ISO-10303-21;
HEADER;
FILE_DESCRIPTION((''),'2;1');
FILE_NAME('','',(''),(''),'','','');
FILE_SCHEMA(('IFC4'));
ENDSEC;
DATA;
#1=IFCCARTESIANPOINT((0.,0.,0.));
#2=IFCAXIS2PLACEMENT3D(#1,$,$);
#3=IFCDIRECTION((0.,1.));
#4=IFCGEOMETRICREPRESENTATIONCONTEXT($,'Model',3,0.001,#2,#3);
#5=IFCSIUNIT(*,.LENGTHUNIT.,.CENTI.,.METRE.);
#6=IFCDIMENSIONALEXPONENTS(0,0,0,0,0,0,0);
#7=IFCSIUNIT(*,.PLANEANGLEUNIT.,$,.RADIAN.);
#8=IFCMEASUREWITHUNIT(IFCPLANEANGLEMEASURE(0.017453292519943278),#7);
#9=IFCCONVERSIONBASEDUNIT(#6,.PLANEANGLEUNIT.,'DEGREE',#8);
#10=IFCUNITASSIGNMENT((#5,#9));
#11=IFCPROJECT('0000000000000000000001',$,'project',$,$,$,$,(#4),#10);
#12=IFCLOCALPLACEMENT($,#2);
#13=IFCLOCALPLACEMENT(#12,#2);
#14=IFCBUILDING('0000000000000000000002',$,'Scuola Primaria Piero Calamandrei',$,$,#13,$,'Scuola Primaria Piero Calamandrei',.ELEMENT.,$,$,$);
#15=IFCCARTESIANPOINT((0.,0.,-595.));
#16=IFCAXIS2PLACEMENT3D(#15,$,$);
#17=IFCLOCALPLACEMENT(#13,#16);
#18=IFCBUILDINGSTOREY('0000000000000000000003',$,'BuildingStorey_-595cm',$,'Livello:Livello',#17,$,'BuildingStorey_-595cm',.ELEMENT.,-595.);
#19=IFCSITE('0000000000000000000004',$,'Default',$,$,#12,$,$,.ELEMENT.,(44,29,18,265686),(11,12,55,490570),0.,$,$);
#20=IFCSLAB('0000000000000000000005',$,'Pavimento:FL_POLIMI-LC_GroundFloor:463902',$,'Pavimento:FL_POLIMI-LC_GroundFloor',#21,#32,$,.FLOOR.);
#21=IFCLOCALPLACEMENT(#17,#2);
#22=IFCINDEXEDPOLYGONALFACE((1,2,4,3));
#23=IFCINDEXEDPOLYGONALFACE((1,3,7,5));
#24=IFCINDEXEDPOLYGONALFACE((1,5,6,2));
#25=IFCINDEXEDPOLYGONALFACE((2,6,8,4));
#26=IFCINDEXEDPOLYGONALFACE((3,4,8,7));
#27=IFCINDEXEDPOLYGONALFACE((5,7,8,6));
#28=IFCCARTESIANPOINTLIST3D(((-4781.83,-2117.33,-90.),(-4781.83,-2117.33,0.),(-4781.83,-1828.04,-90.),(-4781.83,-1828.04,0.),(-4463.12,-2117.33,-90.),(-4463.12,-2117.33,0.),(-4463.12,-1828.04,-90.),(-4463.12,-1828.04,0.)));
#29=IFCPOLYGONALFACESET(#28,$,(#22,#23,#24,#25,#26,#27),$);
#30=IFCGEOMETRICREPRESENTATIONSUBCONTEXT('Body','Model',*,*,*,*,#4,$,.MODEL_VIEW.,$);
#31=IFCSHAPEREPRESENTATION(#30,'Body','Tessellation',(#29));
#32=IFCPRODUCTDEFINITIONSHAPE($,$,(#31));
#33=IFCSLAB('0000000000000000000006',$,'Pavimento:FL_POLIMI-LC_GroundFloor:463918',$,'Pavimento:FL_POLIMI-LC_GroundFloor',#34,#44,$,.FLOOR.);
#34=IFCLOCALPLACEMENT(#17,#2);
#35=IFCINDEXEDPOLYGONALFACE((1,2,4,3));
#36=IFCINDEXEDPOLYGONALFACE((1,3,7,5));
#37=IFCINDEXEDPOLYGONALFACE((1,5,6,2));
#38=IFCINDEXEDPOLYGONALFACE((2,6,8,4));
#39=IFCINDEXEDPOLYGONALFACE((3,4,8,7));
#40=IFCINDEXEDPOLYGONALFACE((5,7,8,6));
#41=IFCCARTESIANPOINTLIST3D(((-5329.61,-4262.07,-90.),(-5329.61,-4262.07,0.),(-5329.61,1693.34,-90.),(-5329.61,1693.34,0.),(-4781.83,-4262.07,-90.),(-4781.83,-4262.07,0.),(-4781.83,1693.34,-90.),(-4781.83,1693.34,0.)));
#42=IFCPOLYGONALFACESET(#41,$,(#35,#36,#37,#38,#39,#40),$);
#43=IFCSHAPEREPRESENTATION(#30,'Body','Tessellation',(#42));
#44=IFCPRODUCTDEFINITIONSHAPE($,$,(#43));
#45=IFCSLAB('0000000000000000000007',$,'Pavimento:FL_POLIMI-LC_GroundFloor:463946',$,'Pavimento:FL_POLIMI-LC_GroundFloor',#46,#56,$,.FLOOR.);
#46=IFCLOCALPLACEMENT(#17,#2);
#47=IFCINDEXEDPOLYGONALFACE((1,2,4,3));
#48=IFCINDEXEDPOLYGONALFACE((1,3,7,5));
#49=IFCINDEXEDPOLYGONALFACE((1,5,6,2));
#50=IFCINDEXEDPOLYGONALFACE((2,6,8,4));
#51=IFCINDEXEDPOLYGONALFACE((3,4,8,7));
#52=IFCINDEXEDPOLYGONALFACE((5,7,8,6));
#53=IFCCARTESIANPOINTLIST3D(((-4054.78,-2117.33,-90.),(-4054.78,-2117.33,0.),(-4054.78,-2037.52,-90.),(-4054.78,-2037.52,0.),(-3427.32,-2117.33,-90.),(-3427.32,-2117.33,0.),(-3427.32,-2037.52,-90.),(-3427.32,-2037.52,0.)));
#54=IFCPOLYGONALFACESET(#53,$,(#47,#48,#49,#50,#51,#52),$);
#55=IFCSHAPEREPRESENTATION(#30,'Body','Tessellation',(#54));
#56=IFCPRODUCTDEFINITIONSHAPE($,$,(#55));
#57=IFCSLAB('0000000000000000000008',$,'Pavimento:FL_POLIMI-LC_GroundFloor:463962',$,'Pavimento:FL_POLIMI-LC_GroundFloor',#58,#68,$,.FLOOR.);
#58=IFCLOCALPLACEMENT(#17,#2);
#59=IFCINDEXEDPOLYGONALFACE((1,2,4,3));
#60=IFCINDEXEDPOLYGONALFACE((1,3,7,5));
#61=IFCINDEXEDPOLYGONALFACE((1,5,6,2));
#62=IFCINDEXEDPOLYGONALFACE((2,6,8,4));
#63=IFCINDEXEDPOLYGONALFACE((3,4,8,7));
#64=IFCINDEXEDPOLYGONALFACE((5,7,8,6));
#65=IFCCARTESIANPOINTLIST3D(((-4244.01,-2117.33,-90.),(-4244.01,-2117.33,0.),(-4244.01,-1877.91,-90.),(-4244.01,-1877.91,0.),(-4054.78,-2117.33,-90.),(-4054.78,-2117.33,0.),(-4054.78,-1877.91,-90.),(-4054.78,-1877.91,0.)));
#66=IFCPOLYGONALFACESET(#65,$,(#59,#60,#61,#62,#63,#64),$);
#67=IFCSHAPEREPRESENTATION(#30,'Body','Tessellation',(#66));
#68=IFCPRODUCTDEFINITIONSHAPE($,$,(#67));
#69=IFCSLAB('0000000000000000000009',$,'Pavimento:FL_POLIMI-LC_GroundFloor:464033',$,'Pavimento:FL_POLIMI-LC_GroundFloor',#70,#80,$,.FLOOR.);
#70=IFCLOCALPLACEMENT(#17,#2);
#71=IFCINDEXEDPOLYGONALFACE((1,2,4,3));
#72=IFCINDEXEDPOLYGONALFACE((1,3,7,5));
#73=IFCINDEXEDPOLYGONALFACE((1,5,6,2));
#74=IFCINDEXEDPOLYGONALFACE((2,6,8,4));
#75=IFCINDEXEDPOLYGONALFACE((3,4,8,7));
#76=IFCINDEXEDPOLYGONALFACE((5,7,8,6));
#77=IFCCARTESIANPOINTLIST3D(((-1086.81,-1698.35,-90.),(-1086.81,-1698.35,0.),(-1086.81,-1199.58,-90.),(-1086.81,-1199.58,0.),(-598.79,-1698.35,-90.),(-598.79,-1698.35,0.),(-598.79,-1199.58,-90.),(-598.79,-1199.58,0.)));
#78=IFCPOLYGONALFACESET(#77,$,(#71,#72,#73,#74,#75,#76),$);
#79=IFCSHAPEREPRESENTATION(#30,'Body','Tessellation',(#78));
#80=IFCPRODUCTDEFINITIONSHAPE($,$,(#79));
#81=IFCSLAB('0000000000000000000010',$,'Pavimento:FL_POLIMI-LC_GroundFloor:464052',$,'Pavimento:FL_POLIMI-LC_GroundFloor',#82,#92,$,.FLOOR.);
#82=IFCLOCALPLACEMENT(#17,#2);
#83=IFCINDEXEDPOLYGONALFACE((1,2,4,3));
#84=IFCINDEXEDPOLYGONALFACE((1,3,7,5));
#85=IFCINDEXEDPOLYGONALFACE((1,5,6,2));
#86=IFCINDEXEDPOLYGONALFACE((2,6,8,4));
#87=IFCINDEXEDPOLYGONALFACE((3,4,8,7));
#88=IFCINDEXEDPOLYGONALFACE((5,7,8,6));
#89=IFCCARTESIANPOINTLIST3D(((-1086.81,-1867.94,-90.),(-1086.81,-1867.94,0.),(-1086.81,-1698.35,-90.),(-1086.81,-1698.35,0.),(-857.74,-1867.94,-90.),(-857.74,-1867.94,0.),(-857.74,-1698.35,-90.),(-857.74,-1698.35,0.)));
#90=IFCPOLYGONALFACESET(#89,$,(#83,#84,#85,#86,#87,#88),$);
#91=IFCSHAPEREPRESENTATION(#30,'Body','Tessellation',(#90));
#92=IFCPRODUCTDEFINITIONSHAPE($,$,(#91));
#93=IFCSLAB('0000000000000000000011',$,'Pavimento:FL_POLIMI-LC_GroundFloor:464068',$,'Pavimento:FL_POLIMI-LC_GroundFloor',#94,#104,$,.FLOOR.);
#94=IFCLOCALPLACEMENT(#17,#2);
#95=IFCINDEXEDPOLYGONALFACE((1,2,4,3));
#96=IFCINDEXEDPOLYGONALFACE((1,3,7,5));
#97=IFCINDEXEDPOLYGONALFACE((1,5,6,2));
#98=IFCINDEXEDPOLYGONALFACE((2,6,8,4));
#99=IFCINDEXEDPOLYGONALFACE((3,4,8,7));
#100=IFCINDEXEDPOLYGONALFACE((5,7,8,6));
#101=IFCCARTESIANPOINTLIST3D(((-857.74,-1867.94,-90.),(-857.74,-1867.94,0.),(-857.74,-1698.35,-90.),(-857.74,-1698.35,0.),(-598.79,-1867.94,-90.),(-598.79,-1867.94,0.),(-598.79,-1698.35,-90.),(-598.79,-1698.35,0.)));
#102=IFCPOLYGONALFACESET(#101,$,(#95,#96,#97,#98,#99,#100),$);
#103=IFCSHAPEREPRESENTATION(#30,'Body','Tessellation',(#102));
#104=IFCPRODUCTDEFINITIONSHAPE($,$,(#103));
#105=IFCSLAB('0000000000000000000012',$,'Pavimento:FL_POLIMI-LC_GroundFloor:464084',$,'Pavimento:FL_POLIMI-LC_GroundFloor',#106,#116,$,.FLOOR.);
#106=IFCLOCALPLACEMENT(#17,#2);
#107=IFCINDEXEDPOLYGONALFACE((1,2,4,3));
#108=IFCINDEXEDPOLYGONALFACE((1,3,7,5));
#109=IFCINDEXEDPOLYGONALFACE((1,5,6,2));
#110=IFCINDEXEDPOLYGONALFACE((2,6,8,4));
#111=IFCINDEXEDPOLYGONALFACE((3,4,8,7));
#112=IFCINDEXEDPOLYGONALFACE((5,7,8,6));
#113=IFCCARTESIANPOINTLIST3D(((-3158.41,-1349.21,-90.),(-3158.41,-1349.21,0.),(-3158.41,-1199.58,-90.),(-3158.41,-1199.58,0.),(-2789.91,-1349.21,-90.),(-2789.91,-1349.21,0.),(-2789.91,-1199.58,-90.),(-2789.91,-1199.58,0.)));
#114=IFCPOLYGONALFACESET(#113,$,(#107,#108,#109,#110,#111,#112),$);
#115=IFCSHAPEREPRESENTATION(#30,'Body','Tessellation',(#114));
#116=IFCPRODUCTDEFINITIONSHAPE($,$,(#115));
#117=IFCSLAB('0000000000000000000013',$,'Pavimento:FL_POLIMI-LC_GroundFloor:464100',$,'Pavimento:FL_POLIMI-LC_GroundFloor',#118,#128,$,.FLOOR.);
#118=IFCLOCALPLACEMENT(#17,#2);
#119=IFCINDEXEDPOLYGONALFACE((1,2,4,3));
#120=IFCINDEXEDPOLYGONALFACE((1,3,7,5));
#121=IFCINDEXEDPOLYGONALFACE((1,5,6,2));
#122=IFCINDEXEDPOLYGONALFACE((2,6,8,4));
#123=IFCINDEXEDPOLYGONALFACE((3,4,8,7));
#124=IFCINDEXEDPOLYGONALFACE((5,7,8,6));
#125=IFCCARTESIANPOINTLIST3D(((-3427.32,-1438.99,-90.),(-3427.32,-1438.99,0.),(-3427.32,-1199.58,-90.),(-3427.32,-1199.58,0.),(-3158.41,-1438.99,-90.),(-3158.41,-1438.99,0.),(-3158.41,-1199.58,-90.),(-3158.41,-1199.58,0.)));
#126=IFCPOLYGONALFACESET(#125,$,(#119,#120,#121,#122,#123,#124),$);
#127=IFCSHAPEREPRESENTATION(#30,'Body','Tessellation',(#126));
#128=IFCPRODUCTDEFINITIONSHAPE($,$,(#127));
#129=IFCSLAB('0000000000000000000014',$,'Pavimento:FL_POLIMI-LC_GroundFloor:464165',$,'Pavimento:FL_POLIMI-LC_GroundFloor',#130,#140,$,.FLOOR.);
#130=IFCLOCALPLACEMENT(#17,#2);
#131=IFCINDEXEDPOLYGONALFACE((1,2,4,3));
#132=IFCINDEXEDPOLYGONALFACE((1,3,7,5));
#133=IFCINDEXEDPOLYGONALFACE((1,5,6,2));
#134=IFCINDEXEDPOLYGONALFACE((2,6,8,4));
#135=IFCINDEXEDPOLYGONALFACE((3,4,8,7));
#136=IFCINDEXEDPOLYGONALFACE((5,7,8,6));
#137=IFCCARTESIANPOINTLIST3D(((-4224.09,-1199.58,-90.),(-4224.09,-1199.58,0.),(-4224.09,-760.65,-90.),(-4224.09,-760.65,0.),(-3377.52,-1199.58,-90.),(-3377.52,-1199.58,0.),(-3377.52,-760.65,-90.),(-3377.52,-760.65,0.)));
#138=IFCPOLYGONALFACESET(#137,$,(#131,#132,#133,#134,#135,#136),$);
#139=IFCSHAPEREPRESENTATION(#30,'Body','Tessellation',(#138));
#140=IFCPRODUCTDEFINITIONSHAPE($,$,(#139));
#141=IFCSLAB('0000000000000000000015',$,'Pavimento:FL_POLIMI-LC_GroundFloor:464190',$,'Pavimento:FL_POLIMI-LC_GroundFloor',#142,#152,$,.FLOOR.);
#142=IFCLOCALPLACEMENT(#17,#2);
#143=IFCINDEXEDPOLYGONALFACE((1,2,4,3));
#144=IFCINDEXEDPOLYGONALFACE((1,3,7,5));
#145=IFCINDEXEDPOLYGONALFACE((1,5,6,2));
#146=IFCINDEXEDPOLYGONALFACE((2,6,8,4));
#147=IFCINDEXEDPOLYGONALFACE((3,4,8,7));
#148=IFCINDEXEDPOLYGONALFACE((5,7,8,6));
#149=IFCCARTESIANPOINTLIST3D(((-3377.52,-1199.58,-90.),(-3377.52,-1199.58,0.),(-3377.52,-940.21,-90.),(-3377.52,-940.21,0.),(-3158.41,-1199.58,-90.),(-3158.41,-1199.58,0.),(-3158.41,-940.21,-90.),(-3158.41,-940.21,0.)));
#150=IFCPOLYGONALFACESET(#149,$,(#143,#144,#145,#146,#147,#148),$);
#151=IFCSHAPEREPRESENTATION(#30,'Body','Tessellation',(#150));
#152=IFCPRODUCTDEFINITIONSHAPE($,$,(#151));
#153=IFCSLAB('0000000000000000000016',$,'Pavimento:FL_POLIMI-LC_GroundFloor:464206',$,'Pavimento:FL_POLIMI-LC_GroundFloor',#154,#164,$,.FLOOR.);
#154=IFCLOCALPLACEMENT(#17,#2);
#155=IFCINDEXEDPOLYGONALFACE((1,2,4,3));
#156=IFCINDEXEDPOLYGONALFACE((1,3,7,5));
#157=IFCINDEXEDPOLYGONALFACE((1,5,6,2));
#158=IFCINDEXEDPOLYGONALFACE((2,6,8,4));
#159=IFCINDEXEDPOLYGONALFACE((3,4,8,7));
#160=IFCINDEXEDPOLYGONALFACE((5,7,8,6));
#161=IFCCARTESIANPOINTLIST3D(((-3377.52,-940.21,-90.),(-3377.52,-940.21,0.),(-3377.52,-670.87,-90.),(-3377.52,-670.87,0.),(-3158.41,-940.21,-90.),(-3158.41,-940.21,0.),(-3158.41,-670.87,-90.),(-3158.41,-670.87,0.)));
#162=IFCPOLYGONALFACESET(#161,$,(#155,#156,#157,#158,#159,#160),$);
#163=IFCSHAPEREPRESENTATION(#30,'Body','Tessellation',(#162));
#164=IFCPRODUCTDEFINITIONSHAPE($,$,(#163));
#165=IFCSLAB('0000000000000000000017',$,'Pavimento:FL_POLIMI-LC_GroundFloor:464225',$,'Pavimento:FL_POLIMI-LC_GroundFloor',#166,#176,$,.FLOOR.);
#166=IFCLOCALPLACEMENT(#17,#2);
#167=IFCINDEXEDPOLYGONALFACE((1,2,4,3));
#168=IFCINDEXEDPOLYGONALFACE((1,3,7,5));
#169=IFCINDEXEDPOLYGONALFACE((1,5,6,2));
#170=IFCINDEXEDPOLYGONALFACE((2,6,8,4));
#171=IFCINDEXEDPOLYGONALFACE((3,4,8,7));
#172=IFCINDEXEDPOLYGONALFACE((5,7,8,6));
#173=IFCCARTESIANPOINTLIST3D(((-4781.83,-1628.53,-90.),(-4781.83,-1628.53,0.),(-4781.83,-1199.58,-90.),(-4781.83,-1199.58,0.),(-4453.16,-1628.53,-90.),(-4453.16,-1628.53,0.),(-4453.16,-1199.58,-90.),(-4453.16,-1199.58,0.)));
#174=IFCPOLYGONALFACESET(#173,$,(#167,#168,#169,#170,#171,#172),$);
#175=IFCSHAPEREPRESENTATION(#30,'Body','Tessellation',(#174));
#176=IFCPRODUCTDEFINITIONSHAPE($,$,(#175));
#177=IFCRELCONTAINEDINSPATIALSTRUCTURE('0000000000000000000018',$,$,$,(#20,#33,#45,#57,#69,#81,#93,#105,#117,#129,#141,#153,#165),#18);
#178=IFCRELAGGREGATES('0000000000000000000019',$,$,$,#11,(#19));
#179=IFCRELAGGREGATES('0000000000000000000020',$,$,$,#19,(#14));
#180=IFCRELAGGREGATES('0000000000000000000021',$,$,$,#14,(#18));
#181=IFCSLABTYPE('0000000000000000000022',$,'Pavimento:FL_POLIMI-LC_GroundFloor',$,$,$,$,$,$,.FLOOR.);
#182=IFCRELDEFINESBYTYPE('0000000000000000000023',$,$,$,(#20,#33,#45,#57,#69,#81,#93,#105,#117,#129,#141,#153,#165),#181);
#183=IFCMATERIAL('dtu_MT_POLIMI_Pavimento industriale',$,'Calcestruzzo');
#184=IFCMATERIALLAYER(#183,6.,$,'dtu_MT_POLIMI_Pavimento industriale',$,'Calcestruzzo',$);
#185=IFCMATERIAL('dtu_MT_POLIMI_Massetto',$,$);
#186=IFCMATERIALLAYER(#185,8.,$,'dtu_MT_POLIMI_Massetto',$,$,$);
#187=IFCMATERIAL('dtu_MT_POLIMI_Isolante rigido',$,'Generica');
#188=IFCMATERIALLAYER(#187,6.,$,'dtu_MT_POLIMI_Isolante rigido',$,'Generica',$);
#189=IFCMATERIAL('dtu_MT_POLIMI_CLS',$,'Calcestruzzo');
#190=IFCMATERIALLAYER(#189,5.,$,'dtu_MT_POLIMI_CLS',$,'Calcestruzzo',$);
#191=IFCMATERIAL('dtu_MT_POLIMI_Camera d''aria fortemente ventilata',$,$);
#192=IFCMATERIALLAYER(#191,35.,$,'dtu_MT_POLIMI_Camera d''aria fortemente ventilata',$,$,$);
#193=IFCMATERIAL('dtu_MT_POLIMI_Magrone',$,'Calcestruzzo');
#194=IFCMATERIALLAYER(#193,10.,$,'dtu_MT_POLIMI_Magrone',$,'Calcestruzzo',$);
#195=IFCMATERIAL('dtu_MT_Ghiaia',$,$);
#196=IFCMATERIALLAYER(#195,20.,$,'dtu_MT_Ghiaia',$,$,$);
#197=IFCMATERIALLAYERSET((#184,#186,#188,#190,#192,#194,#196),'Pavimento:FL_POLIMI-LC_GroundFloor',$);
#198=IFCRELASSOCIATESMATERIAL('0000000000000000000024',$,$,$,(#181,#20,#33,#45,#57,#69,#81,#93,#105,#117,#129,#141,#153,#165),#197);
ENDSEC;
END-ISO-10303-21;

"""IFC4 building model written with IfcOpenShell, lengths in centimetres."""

from ifc_helpers import new_model, entity, si_unit, converted_unit, direction, frame, frame_2d, origin, origin_2d_with_axis, place, context, subcontext, project, spatial, rectangle, extrude, material, layer, layer_set, layer_usage, type_object, element, save


model = new_model("IFC4")

# Units and contexts
model_context = context("Model", 3, precision=0.001, world=origin(), true_north=direction((0.0, 1.0)))
body_context = subcontext(model_context, "Body", "Model", "MODEL_VIEW")
ifc_project = project(units=[si_unit("LENGTHUNIT", "METRE", prefix="CENTI"), converted_unit("PLANEANGLEUNIT", "DEGREE", entity("IfcPlaneAngleMeasure", 0.017453292519943278), si_unit("PLANEANGLEUNIT", "RADIAN"), dimensions=[0, 0, 0, 0, 0, 0, 0])], contexts=[model_context])

# Site, building, storey
site_placement = place(None, origin())
site = spatial("IfcSite", under=ifc_project, at=site_placement, Name="Default", CompositionType="ELEMENT", RefLatitude=(44, 29, 18, 265686), RefLongitude=(11, 12, 55, 490570), RefElevation=0.0)
building_placement = place(site_placement, origin())
building = spatial("IfcBuilding", under=site, at=building_placement, Name="Scuola Primaria Piero Calamandrei", LongName="Scuola Primaria Piero Calamandrei", CompositionType="ELEMENT")
storey_placement = place(building_placement, frame((0.0, 0.0, -595.0)))
storey = spatial("IfcBuildingStorey", under=building, at=storey_placement, Name="BuildingStorey_-595cm", ObjectType="Livello:Livello", LongName="BuildingStorey_-595cm", CompositionType="ELEMENT", Elevation=-595.0)

# Slabs
ifc_material_1 = material(Name="dtu_MT_POLIMI_Pavimento industriale", Category="Calcestruzzo")
ifc_layer_1 = layer(ifc_material_1, 6.0, Name="dtu_MT_POLIMI_Pavimento industriale", Category="Calcestruzzo")
ifc_material_2 = material(Name="dtu_MT_POLIMI_Massetto")
ifc_layer_2 = layer(ifc_material_2, 8.0, Name="dtu_MT_POLIMI_Massetto")
ifc_material_3 = material(Name="dtu_MT_POLIMI_Isolante rigido", Category="Generica")
ifc_layer_3 = layer(ifc_material_3, 6.0, Name="dtu_MT_POLIMI_Isolante rigido", Category="Generica")
ifc_material_4 = material(Name="dtu_MT_POLIMI_CLS", Category="Calcestruzzo")
ifc_layer_4 = layer(ifc_material_4, 5.0, Name="dtu_MT_POLIMI_CLS", Category="Calcestruzzo")
ifc_material_5 = material(Name="dtu_MT_POLIMI_Camera d'aria fortemente ventilata")
ifc_layer_5 = layer(ifc_material_5, 35.0, Name="dtu_MT_POLIMI_Camera d'aria fortemente ventilata")
ifc_material_6 = material(Name="dtu_MT_POLIMI_Magrone", Category="Calcestruzzo")
ifc_layer_6 = layer(ifc_material_6, 10.0, Name="dtu_MT_POLIMI_Magrone", Category="Calcestruzzo")
ifc_material_7 = material(Name="dtu_MT_Ghiaia")
ifc_layer_7 = layer(ifc_material_7, 20.0, Name="dtu_MT_Ghiaia")
ifc_layer_set_1 = layer_set([ifc_layer_1, ifc_layer_2, ifc_layer_3, ifc_layer_4, ifc_layer_5, ifc_layer_6, ifc_layer_7], Name="Pavimento:FL_POLIMI-LC_GroundFloor")
slab_type = type_object("IfcSlabType", Name="Pavimento:FL_POLIMI-LC_GroundFloor", PredefinedType="FLOOR", material=ifc_layer_set_1)
ifc_layer_usage_1 = layer_usage(ifc_layer_set_1, "AXIS3", "POSITIVE", 0.0)
slab_1_placement = place(storey_placement, origin())
element("IfcSlab", 1, at=slab_1_placement, inside=storey, type_object=slab_type, material=ifc_layer_usage_1, Name="Pavimento:FL_POLIMI-LC_GroundFloor:463902", ObjectType="Pavimento:FL_POLIMI-LC_GroundFloor", PredefinedType="FLOOR", context=body_context, shape_type="SweptSolid", body=[
    extrude(rectangle(XDim=289.29, YDim=318.71, at=frame_2d((0.0, 0.0), x_axis=(1.0, 0.0))), frame((-4622.48, -1972.68, 0.0), z_axis=(0.0, 0.0, -1.0), x_axis=(0.0, 1.0, 0.0)), (0.0, 0.0, 1.0), 90.0),
])
ifc_layer_usage_2 = layer_usage(ifc_layer_set_1, "AXIS3", "POSITIVE", 0.0)
slab_2_placement = place(storey_placement, origin())
element("IfcSlab", 2, at=slab_2_placement, inside=storey, type_object=slab_type, material=ifc_layer_usage_2, Name="Pavimento:FL_POLIMI-LC_GroundFloor:463918", ObjectType="Pavimento:FL_POLIMI-LC_GroundFloor", PredefinedType="FLOOR", context=body_context, shape_type="SweptSolid", body=[
    extrude(rectangle(XDim=5955.41, YDim=547.78, at=frame_2d((0.0, 0.0), x_axis=(1.0, 0.0))), frame((-5055.72, -1284.37, 0.0), z_axis=(0.0, 0.0, -1.0), x_axis=(0.0, 1.0, 0.0)), (0.0, 0.0, 1.0), 90.0),
])
ifc_layer_usage_3 = layer_usage(ifc_layer_set_1, "AXIS3", "POSITIVE", 0.0)
slab_3_placement = place(storey_placement, origin())
element("IfcSlab", 3, at=slab_3_placement, inside=storey, type_object=slab_type, material=ifc_layer_usage_3, Name="Pavimento:FL_POLIMI-LC_GroundFloor:463946", ObjectType="Pavimento:FL_POLIMI-LC_GroundFloor", PredefinedType="FLOOR", context=body_context, shape_type="SweptSolid", body=[
    extrude(rectangle(XDim=79.8, YDim=627.46, at=frame_2d((0.0, 0.0), x_axis=(1.0, 0.0))), frame((-3741.05, -2077.42, 0.0), z_axis=(0.0, 0.0, -1.0), x_axis=(0.0, 1.0, 0.0)), (0.0, 0.0, 1.0), 90.0),
])
ifc_layer_usage_4 = layer_usage(ifc_layer_set_1, "AXIS3", "POSITIVE", 0.0)
slab_4_placement = place(storey_placement, origin())
element("IfcSlab", 4, at=slab_4_placement, inside=storey, type_object=slab_type, material=ifc_layer_usage_4, Name="Pavimento:FL_POLIMI-LC_GroundFloor:463962", ObjectType="Pavimento:FL_POLIMI-LC_GroundFloor", PredefinedType="FLOOR", context=body_context, shape_type="SweptSolid", body=[
    extrude(rectangle(XDim=239.41, YDim=189.23, at=frame_2d((0.0, 0.0), x_axis=(1.0, 0.0))), frame((-4149.39, -1997.62, 0.0), z_axis=(0.0, 0.0, -1.0), x_axis=(0.0, 1.0, 0.0)), (0.0, 0.0, 1.0), 90.0),
])
ifc_layer_usage_5 = layer_usage(ifc_layer_set_1, "AXIS3", "POSITIVE", 0.0)
slab_5_placement = place(storey_placement, origin())
element("IfcSlab", 5, at=slab_5_placement, inside=storey, type_object=slab_type, material=ifc_layer_usage_5, Name="Pavimento:FL_POLIMI-LC_GroundFloor:464033", ObjectType="Pavimento:FL_POLIMI-LC_GroundFloor", PredefinedType="FLOOR", context=body_context, shape_type="SweptSolid", body=[
    extrude(rectangle(XDim=498.78, YDim=488.02, at=frame_2d((0.0, 0.0), x_axis=(1.0, 0.0))), frame((-842.8, -1448.96, 0.0), z_axis=(0.0, 0.0, -1.0), x_axis=(0.0, 1.0, 0.0)), (0.0, 0.0, 1.0), 90.0),
])
ifc_layer_usage_6 = layer_usage(ifc_layer_set_1, "AXIS3", "POSITIVE", 0.0)
slab_6_placement = place(storey_placement, origin())
element("IfcSlab", 6, at=slab_6_placement, inside=storey, type_object=slab_type, material=ifc_layer_usage_6, Name="Pavimento:FL_POLIMI-LC_GroundFloor:464052", ObjectType="Pavimento:FL_POLIMI-LC_GroundFloor", PredefinedType="FLOOR", context=body_context, shape_type="SweptSolid", body=[
    extrude(rectangle(XDim=169.58, YDim=229.07, at=frame_2d((0.0, 0.0), x_axis=(1.0, 0.0))), frame((-972.28, -1783.15, 0.0), z_axis=(0.0, 0.0, -1.0), x_axis=(0.0, 1.0, 0.0)), (0.0, 0.0, 1.0), 90.0),
])
ifc_layer_usage_7 = layer_usage(ifc_layer_set_1, "AXIS3", "POSITIVE", 0.0)
slab_7_placement = place(storey_placement, origin())
element("IfcSlab", 7, at=slab_7_placement, inside=storey, type_object=slab_type, material=ifc_layer_usage_7, Name="Pavimento:FL_POLIMI-LC_GroundFloor:464068", ObjectType="Pavimento:FL_POLIMI-LC_GroundFloor", PredefinedType="FLOOR", context=body_context, shape_type="SweptSolid", body=[
    extrude(rectangle(XDim=169.58, YDim=258.95, at=frame_2d((0.0, 0.0), x_axis=(1.0, 0.0))), frame((-728.27, -1783.15, 0.0), z_axis=(0.0, 0.0, -1.0), x_axis=(0.0, 1.0, 0.0)), (0.0, 0.0, 1.0), 90.0),
])
ifc_layer_usage_8 = layer_usage(ifc_layer_set_1, "AXIS3", "POSITIVE", 0.0)
slab_8_placement = place(storey_placement, origin())
element("IfcSlab", 8, at=slab_8_placement, inside=storey, type_object=slab_type, material=ifc_layer_usage_8, Name="Pavimento:FL_POLIMI-LC_GroundFloor:464084", ObjectType="Pavimento:FL_POLIMI-LC_GroundFloor", PredefinedType="FLOOR", context=body_context, shape_type="SweptSolid", body=[
    extrude(rectangle(XDim=149.63, YDim=368.51, at=frame_2d((0.0, 0.0), x_axis=(1.0, 0.0))), frame((-2974.16, -1274.39, 0.0), z_axis=(0.0, 0.0, -1.0), x_axis=(0.0, 1.0, 0.0)), (0.0, 0.0, 1.0), 90.0),
])
ifc_layer_usage_9 = layer_usage(ifc_layer_set_1, "AXIS3", "POSITIVE", 0.0)
slab_9_placement = place(storey_placement, origin())
element("IfcSlab", 9, at=slab_9_placement, inside=storey, type_object=slab_type, material=ifc_layer_usage_9, Name="Pavimento:FL_POLIMI-LC_GroundFloor:464100", ObjectType="Pavimento:FL_POLIMI-LC_GroundFloor", PredefinedType="FLOOR", context=body_context, shape_type="SweptSolid", body=[
    extrude(rectangle(XDim=239.41, YDim=268.91, at=origin_2d_with_axis()), frame((-3292.87, -1319.28, 0.0), z_axis=(0.0, 0.0, -1.0), x_axis=(0.0, 1.0, 0.0)), (0.0, 0.0, 1.0), 90.0),
])
ifc_layer_usage_10 = layer_usage(ifc_layer_set_1, "AXIS3", "POSITIVE", 0.0)
slab_10_placement = place(storey_placement, origin())
element("IfcSlab", 10, at=slab_10_placement, inside=storey, type_object=slab_type, material=ifc_layer_usage_10, Name="Pavimento:FL_POLIMI-LC_GroundFloor:464165", ObjectType="Pavimento:FL_POLIMI-LC_GroundFloor", PredefinedType="FLOOR", context=body_context, shape_type="SweptSolid", body=[
    extrude(rectangle(XDim=438.92, YDim=846.57, at=frame_2d((0.0, 0.0), x_axis=(1.0, 0.0))), frame((-3800.81, -980.11, 0.0), z_axis=(0.0, 0.0, -1.0), x_axis=(0.0, 1.0, 0.0)), (0.0, 0.0, 1.0), 90.0),
])
ifc_layer_usage_11 = layer_usage(ifc_layer_set_1, "AXIS3", "POSITIVE", 0.0)
slab_11_placement = place(storey_placement, origin())
element("IfcSlab", 11, at=slab_11_placement, inside=storey, type_object=slab_type, material=ifc_layer_usage_11, Name="Pavimento:FL_POLIMI-LC_GroundFloor:464190", ObjectType="Pavimento:FL_POLIMI-LC_GroundFloor", PredefinedType="FLOOR", context=body_context, shape_type="SweptSolid", body=[
    extrude(rectangle(XDim=259.36, YDim=219.11, at=frame_2d((0.0, 0.0), x_axis=(1.0, 0.0))), frame((-3267.97, -1069.89, 0.0), z_axis=(0.0, 0.0, -1.0), x_axis=(0.0, 1.0, 0.0)), (0.0, 0.0, 1.0), 90.0),
])
ifc_layer_usage_12 = layer_usage(ifc_layer_set_1, "AXIS3", "POSITIVE", 0.0)
slab_12_placement = place(storey_placement, origin())
element("IfcSlab", 12, at=slab_12_placement, inside=storey, type_object=slab_type, material=ifc_layer_usage_12, Name="Pavimento:FL_POLIMI-LC_GroundFloor:464206", ObjectType="Pavimento:FL_POLIMI-LC_GroundFloor", PredefinedType="FLOOR", context=body_context, shape_type="SweptSolid", body=[
    extrude(rectangle(XDim=219.11, YDim=269.34, at=frame_2d((0.0, 0.0), x_axis=(1.0, 0.0))), frame((-3267.97, -805.54, 0.0), z_axis=(0.0, 0.0, -1.0), x_axis=(1.0, 0.0, 0.0)), (0.0, 0.0, 1.0), 90.0),
])
ifc_layer_usage_13 = layer_usage(ifc_layer_set_1, "AXIS3", "POSITIVE", 0.0)
slab_13_placement = place(storey_placement, origin())
element("IfcSlab", 13, at=slab_13_placement, inside=storey, type_object=slab_type, material=ifc_layer_usage_13, Name="Pavimento:FL_POLIMI-LC_GroundFloor:464225", ObjectType="Pavimento:FL_POLIMI-LC_GroundFloor", PredefinedType="FLOOR", context=body_context, shape_type="SweptSolid", body=[
    extrude(rectangle(XDim=428.95, YDim=328.67, at=frame_2d((0.0, 0.0), x_axis=(1.0, 0.0))), frame((-4617.5, -1414.05, 0.0), z_axis=(0.0, 0.0, -1.0), x_axis=(0.0, 1.0, 0.0)), (0.0, 0.0, 1.0), 90.0),
])

save(model, "model.ifc")
